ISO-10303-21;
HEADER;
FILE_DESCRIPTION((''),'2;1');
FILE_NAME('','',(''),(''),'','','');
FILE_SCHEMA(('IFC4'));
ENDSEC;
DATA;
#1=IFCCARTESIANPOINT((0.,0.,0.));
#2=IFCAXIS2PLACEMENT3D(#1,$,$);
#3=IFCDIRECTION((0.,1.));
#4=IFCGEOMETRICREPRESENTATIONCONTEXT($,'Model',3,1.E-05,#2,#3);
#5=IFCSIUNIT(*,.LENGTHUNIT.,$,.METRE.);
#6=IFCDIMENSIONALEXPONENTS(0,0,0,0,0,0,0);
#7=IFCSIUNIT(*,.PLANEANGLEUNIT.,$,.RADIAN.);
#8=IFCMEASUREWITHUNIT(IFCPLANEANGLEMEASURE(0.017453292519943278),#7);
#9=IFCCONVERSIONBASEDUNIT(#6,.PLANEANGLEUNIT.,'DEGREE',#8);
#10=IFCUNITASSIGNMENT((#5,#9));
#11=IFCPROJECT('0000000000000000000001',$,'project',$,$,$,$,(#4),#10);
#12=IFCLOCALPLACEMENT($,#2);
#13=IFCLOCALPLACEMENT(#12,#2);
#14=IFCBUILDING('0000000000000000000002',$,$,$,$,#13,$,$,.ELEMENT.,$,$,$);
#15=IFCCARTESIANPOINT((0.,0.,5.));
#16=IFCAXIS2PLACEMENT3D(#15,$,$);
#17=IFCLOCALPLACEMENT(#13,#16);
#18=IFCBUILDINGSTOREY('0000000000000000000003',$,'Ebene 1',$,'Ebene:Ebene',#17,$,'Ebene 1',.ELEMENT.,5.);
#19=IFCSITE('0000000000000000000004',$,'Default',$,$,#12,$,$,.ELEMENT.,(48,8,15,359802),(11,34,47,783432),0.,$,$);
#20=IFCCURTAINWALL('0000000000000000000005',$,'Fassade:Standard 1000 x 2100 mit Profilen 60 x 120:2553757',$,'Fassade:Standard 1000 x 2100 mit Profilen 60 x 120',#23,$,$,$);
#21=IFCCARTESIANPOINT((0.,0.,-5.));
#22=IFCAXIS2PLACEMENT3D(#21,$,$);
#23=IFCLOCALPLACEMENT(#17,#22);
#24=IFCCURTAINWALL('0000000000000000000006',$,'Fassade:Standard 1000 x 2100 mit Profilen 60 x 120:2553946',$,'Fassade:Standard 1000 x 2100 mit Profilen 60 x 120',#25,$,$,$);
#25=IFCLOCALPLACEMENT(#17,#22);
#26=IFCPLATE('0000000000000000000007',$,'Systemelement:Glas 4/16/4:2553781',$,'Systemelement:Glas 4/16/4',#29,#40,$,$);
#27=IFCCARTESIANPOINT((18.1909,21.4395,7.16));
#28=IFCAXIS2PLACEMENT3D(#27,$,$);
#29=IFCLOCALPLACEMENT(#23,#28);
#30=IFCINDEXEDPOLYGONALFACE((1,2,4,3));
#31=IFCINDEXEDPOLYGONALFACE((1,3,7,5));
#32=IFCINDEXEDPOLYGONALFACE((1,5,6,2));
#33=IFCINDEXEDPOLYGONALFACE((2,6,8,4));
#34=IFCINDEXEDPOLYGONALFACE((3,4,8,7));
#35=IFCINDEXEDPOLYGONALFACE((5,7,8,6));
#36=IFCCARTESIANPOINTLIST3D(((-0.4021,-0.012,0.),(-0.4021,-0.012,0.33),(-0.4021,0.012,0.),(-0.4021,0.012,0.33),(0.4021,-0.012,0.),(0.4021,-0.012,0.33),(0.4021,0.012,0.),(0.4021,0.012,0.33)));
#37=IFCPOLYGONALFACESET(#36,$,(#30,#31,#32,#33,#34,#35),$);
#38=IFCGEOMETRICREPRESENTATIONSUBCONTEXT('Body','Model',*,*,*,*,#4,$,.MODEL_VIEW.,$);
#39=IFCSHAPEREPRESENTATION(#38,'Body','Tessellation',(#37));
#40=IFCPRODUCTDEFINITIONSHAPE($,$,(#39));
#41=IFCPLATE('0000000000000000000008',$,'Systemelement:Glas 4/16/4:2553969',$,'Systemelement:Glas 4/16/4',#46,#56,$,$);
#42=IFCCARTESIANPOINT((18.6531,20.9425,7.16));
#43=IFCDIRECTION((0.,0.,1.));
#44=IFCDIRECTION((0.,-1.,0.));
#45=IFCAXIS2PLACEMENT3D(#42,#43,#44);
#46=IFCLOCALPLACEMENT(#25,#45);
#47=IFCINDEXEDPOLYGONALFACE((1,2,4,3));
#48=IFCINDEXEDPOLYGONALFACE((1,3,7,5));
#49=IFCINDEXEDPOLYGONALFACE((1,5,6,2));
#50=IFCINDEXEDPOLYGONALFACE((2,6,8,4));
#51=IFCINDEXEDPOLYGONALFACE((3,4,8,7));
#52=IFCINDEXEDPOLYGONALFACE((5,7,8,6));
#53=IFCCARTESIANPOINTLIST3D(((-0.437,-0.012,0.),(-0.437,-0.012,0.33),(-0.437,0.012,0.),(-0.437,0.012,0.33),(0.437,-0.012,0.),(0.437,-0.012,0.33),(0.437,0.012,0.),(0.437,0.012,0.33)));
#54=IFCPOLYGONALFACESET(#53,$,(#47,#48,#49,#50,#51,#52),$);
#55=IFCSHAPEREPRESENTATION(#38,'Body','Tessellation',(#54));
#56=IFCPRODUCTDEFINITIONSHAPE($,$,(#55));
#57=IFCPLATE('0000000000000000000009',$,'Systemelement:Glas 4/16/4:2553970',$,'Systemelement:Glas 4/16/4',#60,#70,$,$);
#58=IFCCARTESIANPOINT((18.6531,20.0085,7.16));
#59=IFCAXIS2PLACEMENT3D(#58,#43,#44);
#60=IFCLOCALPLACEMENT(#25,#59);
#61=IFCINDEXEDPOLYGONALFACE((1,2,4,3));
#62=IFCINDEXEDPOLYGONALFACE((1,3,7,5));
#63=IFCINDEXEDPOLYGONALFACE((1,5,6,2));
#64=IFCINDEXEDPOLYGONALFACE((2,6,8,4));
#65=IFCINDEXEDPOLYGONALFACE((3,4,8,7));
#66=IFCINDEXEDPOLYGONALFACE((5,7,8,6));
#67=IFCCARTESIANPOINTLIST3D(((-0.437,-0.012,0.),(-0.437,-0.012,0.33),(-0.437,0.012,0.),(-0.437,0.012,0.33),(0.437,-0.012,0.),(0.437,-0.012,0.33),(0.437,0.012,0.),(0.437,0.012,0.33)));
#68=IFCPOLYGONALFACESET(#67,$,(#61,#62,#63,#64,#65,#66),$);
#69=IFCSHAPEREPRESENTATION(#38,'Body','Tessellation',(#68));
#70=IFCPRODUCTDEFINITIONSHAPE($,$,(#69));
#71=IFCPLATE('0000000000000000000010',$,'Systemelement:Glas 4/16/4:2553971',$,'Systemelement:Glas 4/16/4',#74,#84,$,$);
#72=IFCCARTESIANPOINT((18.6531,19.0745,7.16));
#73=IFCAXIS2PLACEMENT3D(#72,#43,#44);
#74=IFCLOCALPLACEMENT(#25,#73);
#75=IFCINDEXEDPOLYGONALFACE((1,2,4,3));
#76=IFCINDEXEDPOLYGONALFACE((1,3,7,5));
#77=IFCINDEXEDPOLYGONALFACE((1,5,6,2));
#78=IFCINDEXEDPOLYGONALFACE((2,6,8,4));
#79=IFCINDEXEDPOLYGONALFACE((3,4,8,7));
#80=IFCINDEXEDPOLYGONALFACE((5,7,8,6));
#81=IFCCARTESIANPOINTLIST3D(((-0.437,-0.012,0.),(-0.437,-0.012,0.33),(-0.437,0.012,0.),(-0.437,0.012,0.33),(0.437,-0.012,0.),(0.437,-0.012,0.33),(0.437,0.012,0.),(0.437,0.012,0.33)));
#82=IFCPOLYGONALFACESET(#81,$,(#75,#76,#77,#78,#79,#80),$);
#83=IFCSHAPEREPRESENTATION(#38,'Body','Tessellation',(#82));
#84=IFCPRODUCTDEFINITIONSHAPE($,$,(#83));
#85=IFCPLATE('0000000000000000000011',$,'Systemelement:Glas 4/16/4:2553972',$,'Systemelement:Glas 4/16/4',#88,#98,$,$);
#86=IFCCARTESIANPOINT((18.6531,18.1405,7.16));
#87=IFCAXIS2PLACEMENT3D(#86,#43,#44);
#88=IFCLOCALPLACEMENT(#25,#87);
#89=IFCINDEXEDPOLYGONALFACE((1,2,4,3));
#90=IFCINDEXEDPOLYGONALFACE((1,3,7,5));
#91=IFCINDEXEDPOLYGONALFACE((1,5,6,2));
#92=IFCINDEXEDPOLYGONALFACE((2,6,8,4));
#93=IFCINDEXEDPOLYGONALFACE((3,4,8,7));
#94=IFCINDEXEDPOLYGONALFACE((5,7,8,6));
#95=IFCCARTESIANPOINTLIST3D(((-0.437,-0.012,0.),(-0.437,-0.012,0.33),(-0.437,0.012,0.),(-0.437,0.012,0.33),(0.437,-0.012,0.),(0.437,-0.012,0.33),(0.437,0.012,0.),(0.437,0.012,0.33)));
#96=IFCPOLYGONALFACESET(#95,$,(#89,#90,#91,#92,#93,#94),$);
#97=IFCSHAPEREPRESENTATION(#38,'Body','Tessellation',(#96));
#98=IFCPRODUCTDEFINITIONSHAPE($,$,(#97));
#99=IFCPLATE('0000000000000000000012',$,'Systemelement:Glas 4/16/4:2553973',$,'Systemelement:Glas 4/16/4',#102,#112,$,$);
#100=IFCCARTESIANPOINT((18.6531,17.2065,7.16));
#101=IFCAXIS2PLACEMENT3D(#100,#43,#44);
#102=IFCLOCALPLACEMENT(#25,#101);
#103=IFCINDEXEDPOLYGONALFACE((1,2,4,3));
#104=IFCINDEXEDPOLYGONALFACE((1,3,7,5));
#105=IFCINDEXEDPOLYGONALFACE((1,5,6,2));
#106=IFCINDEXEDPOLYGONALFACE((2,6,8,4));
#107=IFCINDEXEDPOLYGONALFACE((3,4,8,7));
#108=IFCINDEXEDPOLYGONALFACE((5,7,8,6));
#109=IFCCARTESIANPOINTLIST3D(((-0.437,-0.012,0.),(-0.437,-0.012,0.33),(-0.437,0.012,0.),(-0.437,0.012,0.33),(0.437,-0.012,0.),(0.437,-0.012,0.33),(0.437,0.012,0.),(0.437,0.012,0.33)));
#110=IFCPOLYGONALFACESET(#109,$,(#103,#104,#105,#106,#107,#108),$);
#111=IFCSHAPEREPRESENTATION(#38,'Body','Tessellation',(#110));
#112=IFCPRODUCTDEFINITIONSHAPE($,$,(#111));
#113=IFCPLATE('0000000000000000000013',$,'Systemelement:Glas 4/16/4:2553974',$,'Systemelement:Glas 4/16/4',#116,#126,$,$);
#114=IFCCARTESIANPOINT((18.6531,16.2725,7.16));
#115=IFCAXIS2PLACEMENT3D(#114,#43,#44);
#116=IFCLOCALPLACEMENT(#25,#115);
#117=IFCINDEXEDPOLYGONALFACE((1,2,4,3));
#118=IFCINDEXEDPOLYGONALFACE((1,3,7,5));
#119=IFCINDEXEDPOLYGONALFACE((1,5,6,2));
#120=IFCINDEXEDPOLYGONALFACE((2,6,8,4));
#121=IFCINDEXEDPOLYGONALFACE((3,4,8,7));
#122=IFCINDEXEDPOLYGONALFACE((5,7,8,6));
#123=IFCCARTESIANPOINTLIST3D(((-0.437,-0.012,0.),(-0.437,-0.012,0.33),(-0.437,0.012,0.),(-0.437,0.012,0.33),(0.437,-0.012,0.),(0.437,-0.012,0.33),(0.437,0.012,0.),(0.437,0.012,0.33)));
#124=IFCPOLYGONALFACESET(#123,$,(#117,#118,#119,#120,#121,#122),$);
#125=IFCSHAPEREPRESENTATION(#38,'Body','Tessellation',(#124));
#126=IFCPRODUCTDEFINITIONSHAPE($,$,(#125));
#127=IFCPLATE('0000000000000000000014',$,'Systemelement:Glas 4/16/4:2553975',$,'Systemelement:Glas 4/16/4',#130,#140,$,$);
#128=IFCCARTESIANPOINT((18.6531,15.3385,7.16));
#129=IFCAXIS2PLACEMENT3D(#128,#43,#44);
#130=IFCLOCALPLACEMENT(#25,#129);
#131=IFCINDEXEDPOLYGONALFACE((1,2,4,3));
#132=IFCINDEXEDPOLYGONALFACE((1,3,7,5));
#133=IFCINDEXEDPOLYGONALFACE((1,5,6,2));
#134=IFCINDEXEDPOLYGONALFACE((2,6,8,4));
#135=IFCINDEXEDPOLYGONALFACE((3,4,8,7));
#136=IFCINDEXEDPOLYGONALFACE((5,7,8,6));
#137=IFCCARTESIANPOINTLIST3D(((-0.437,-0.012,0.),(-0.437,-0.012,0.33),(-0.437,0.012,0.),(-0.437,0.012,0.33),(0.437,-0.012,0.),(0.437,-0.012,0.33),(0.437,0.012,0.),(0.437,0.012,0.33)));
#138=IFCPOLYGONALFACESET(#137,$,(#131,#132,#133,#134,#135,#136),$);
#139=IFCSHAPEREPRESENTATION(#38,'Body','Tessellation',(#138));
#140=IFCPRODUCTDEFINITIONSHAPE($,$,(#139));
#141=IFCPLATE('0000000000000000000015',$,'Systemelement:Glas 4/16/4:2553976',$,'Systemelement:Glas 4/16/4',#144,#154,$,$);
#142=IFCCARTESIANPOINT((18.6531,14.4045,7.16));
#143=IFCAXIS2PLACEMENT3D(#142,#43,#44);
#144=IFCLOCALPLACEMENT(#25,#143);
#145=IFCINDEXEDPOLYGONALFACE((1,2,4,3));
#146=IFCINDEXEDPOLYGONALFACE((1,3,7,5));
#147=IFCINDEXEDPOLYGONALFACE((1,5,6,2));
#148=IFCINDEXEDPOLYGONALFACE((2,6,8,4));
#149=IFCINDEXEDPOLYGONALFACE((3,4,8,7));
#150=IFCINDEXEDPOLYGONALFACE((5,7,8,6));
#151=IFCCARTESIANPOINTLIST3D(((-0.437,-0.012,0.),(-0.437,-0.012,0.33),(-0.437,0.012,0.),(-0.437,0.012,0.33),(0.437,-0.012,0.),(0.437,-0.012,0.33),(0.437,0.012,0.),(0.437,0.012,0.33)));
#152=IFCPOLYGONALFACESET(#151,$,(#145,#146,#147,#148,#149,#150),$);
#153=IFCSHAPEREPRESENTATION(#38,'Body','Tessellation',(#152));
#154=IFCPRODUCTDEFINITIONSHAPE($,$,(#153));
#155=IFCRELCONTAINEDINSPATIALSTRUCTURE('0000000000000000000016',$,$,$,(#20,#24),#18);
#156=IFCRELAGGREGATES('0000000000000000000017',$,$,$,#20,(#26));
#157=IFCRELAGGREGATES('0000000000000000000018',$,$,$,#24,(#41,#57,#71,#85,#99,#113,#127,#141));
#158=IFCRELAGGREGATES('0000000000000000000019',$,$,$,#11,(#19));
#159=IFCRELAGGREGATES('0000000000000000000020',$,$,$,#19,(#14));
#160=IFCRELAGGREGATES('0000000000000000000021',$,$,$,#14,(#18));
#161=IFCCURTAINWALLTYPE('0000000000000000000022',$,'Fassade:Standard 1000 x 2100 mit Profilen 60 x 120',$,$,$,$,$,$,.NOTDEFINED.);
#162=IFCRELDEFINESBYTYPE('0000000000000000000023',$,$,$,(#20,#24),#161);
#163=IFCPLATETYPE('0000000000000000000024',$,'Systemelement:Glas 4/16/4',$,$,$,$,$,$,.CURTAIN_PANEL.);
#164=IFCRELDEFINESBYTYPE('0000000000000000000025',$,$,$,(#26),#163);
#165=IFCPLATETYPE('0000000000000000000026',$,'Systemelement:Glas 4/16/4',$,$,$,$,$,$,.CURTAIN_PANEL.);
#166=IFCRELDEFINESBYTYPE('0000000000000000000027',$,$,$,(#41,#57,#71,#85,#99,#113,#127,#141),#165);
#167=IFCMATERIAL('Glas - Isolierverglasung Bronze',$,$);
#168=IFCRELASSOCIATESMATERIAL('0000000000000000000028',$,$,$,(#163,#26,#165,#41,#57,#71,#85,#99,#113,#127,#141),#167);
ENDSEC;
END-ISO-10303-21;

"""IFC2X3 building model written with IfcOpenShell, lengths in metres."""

from ifc_helpers import new_model, entity, si_unit, converted_unit, direction, frame, origin, origin_2d_with_axis, place, context, subcontext, project, spatial, rectangle, extrude, source, transform, mapped, material, type_object, type_shapes, element, aggregate, save


model = new_model("IFC2X3")

# Units and contexts
model_context = context("Model", 3, precision=1e-05, world=origin(), true_north=direction((0.0, 1.0)))
body_context = subcontext(model_context, "Body", "Model", "MODEL_VIEW")
ifc_project = project(units=[si_unit("LENGTHUNIT", "METRE"), converted_unit("PLANEANGLEUNIT", "DEGREE", entity("IfcPlaneAngleMeasure", 0.017453292519943278), si_unit("PLANEANGLEUNIT", "RADIAN"), dimensions=[0, 0, 0, 0, 0, 0, 0])], contexts=[model_context])

# Site, building, storey
site_placement = place(None, origin())
site = spatial("IfcSite", under=ifc_project, at=site_placement, Name="Default", CompositionType="ELEMENT", RefLatitude=(48, 8, 15, 359802), RefLongitude=(11, 34, 47, 783432), RefElevation=0.0)
building_placement = place(site_placement, origin())
building = spatial("IfcBuilding", under=site, at=building_placement, CompositionType="ELEMENT")
storey_placement = place(building_placement, frame((0.0, 0.0, 5.0)))
storey = spatial("IfcBuildingStorey", under=building, at=storey_placement, Name="Ebene 1", ObjectType="Ebene:Ebene", LongName="Ebene 1", CompositionType="ELEMENT", Elevation=5.0)

# Curtain wall
curtain_wall_type = type_object("IfcCurtainWallType", Name="Fassade:Standard 1000 x 2100 mit Profilen 60 x 120", PredefinedType="NOTDEFINED")
curtain_wall_1_placement = place(storey_placement, frame((0.0, 0.0, -5.0)))
curtain_wall_1 = element("IfcCurtainWall", 1, at=curtain_wall_1_placement, inside=storey, type_object=curtain_wall_type, Name="Fassade:Standard 1000 x 2100 mit Profilen 60 x 120:2553757", ObjectType="Fassade:Standard 1000 x 2100 mit Profilen 60 x 120")

# Curtain wall
curtain_wall_2_placement = place(storey_placement, frame((0.0, 0.0, -5.0)))
curtain_wall_2 = element("IfcCurtainWall", 2, at=curtain_wall_2_placement, inside=storey, type_object=curtain_wall_type, Name="Fassade:Standard 1000 x 2100 mit Profilen 60 x 120:2553946", ObjectType="Fassade:Standard 1000 x 2100 mit Profilen 60 x 120")

# Plates
ifc_material_1 = material(Name="Glas - Isolierverglasung Bronze")
plate_type_1 = type_object("IfcPlateType", Name="Systemelement:Glas 4/16/4", PredefinedType="CURTAIN_PANEL", material=ifc_material_1)
shared_shape_1 = source(origin(), body_context, "Body", "SweptSolid", [
    extrude(rectangle(XDim=0.024, YDim=0.8043, at=origin_2d_with_axis()), frame((0.0, 0.0, 0.0), z_axis=(0.0, 0.0, 1.0), x_axis=(0.0, 1.0, 0.0)), (0.0, 0.0, 1.0), 0.33),
])
type_shapes(plate_type_1, [shared_shape_1])
plate_1_placement = place(curtain_wall_1_placement, frame((18.1909, 21.4395, 7.16)))
plate_1 = element("IfcPlate", 3, at=plate_1_placement, type_object=plate_type_1, material=ifc_material_1, Name="Systemelement:Glas 4/16/4:2553781", ObjectType="Systemelement:Glas 4/16/4", context=body_context, shape_type="MappedRepresentation", body=[
    mapped(shared_shape_1, transform((0.0, 0.0, 0.0), scale=1.0)),
])
aggregate(curtain_wall_1, [plate_1])
plate_type_2 = type_object("IfcPlateType", Name="Systemelement:Glas 4/16/4", PredefinedType="CURTAIN_PANEL", material=ifc_material_1)
shared_shape_2 = source(origin(), body_context, "Body", "SweptSolid", [
    extrude(rectangle(XDim=0.024, YDim=0.874, at=origin_2d_with_axis()), frame((0.0, 0.0, 0.0), z_axis=(0.0, 0.0, 1.0), x_axis=(0.0, 1.0, 0.0)), (0.0, 0.0, 1.0), 0.33),
])
type_shapes(plate_type_2, [shared_shape_2])
plate_2_placement = place(curtain_wall_2_placement, frame((18.6531, 20.9425, 7.16), z_axis=(0.0, 0.0, 1.0), x_axis=(0.0, -1.0, 0.0)))
plate_2 = element("IfcPlate", 4, at=plate_2_placement, type_object=plate_type_2, material=ifc_material_1, Name="Systemelement:Glas 4/16/4:2553969", ObjectType="Systemelement:Glas 4/16/4", context=body_context, shape_type="MappedRepresentation", body=[
    mapped(shared_shape_2, transform((0.0, 0.0, 0.0), scale=1.0)),
])
plate_3_placement = place(curtain_wall_2_placement, frame((18.6531, 20.0085, 7.16), z_axis=(0.0, 0.0, 1.0), x_axis=(0.0, -1.0, 0.0)))
plate_3 = element("IfcPlate", 5, at=plate_3_placement, type_object=plate_type_2, material=ifc_material_1, Name="Systemelement:Glas 4/16/4:2553970", ObjectType="Systemelement:Glas 4/16/4", context=body_context, shape_type="MappedRepresentation", body=[
    mapped(shared_shape_2, transform((0.0, 0.0, 0.0), scale=1.0)),
])
plate_4_placement = place(curtain_wall_2_placement, frame((18.6531, 19.0745, 7.16), z_axis=(0.0, 0.0, 1.0), x_axis=(0.0, -1.0, 0.0)))
plate_4 = element("IfcPlate", 6, at=plate_4_placement, type_object=plate_type_2, material=ifc_material_1, Name="Systemelement:Glas 4/16/4:2553971", ObjectType="Systemelement:Glas 4/16/4", context=body_context, shape_type="MappedRepresentation", body=[
    mapped(shared_shape_2, transform((0.0, 0.0, 0.0), scale=1.0)),
])
plate_5_placement = place(curtain_wall_2_placement, frame((18.6531, 18.1405, 7.16), z_axis=(0.0, 0.0, 1.0), x_axis=(0.0, -1.0, 0.0)))
plate_5 = element("IfcPlate", 7, at=plate_5_placement, type_object=plate_type_2, material=ifc_material_1, Name="Systemelement:Glas 4/16/4:2553972", ObjectType="Systemelement:Glas 4/16/4", context=body_context, shape_type="MappedRepresentation", body=[
    mapped(shared_shape_2, transform((0.0, 0.0, 0.0), scale=1.0)),
])
plate_6_placement = place(curtain_wall_2_placement, frame((18.6531, 17.2065, 7.16), z_axis=(0.0, 0.0, 1.0), x_axis=(0.0, -1.0, 0.0)))
plate_6 = element("IfcPlate", 8, at=plate_6_placement, type_object=plate_type_2, material=ifc_material_1, Name="Systemelement:Glas 4/16/4:2553973", ObjectType="Systemelement:Glas 4/16/4", context=body_context, shape_type="MappedRepresentation", body=[
    mapped(shared_shape_2, transform((0.0, 0.0, 0.0), scale=1.0)),
])
plate_7_placement = place(curtain_wall_2_placement, frame((18.6531, 16.2725, 7.16), z_axis=(0.0, 0.0, 1.0), x_axis=(0.0, -1.0, 0.0)))
plate_7 = element("IfcPlate", 9, at=plate_7_placement, type_object=plate_type_2, material=ifc_material_1, Name="Systemelement:Glas 4/16/4:2553974", ObjectType="Systemelement:Glas 4/16/4", context=body_context, shape_type="MappedRepresentation", body=[
    mapped(shared_shape_2, transform((0.0, 0.0, 0.0), scale=1.0)),
])
plate_8_placement = place(curtain_wall_2_placement, frame((18.6531, 15.3385, 7.16), z_axis=(0.0, 0.0, 1.0), x_axis=(0.0, -1.0, 0.0)))
plate_8 = element("IfcPlate", 10, at=plate_8_placement, type_object=plate_type_2, material=ifc_material_1, Name="Systemelement:Glas 4/16/4:2553975", ObjectType="Systemelement:Glas 4/16/4", context=body_context, shape_type="MappedRepresentation", body=[
    mapped(shared_shape_2, transform((0.0, 0.0, 0.0), scale=1.0)),
])
plate_9_placement = place(curtain_wall_2_placement, frame((18.6531, 14.4045, 7.16), z_axis=(0.0, 0.0, 1.0), x_axis=(0.0, -1.0, 0.0)))
plate_9 = element("IfcPlate", 11, at=plate_9_placement, type_object=plate_type_2, material=ifc_material_1, Name="Systemelement:Glas 4/16/4:2553976", ObjectType="Systemelement:Glas 4/16/4", context=body_context, shape_type="MappedRepresentation", body=[
    mapped(shared_shape_2, transform((0.0, 0.0, 0.0), scale=1.0)),
])
aggregate(curtain_wall_2, [plate_2, plate_3, plate_4, plate_5, plate_6, plate_7, plate_8, plate_9])

save(model, "model.ifc")
